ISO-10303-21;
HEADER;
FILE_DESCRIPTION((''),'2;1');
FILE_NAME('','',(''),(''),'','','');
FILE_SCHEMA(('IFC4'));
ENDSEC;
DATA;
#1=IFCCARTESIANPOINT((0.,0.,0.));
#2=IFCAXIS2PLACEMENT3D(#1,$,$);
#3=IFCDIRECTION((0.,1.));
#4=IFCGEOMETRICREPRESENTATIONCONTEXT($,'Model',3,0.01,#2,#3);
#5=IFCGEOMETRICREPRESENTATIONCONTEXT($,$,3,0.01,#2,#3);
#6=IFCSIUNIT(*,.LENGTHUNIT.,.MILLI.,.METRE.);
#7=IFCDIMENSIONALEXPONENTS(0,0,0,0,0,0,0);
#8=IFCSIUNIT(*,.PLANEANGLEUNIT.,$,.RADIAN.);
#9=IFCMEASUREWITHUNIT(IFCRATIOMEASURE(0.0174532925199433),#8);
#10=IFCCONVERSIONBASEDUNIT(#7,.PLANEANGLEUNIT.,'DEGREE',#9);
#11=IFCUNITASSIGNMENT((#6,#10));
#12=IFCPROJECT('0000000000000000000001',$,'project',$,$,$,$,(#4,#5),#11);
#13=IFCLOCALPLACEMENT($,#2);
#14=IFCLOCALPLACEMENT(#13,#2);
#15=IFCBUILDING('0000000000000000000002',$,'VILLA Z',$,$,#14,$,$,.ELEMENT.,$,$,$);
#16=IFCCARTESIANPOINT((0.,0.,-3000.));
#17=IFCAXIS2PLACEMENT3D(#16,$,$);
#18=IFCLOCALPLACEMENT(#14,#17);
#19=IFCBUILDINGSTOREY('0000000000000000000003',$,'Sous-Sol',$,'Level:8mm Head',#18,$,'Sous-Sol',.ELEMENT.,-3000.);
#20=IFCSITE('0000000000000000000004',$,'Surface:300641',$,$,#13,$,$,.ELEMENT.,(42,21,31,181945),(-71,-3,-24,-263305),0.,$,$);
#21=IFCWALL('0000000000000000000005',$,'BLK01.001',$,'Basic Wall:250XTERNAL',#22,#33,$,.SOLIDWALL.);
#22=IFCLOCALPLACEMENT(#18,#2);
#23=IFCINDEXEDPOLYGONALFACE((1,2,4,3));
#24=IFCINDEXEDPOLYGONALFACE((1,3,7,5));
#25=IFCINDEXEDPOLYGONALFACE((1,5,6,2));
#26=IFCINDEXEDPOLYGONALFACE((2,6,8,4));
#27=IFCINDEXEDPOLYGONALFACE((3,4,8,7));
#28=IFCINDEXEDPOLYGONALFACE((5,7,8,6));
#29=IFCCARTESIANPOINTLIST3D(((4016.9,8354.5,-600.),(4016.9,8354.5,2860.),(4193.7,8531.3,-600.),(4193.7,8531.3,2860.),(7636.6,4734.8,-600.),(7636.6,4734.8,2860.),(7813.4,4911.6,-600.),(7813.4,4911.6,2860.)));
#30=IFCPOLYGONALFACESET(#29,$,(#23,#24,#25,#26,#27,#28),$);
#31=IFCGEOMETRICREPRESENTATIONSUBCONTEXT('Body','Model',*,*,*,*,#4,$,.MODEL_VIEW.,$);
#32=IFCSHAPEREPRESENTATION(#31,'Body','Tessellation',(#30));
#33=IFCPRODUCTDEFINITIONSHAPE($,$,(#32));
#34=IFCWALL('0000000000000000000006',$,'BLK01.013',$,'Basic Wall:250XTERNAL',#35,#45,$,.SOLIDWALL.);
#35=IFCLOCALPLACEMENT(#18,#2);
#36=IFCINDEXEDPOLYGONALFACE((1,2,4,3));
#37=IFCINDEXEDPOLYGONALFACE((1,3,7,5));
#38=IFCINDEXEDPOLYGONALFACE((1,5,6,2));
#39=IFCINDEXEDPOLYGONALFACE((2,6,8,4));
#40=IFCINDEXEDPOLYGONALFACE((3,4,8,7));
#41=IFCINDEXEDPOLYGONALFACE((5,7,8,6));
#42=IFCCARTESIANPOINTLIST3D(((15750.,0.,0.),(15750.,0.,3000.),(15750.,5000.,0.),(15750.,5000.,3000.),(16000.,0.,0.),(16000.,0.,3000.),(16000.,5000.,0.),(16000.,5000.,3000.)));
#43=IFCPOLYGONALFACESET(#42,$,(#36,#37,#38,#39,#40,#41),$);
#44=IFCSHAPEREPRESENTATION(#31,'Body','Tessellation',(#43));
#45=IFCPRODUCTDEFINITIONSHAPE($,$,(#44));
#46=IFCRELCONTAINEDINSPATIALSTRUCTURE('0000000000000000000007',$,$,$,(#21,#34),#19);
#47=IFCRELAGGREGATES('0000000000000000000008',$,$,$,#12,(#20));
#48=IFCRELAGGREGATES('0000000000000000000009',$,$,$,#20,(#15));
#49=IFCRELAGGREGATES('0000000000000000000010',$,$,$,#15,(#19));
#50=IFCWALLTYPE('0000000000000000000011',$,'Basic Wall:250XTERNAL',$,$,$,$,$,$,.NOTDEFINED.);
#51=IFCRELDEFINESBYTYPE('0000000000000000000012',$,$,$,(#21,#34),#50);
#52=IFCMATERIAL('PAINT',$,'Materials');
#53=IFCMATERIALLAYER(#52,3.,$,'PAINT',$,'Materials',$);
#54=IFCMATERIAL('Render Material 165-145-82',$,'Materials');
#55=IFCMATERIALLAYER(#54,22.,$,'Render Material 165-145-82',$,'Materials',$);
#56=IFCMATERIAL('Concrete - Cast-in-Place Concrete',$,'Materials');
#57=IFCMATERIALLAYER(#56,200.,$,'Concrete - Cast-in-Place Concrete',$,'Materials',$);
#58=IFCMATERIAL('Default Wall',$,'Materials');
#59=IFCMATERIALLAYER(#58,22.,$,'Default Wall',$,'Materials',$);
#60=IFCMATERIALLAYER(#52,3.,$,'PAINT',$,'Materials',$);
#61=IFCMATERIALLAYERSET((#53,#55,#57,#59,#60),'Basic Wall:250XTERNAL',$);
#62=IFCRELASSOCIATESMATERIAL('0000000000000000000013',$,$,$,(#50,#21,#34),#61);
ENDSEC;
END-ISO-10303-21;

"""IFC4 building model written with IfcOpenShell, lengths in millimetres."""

from ifc_helpers import new_model, entity, si_unit, converted_unit, direction, frame, frame_2d, origin, place, context, subcontext, project, spatial, polyline, rectangle, extrude, clip, bounded_halfspace, material, layer, layer_set, layer_usage, type_object, element, save


model = new_model("IFC4")

# Units and contexts
model_context = context("Model", 3, precision=0.01, world=origin(), true_north=direction((0.0, 1.0)))
context_of_model = context(None, 3, precision=0.01, world=origin(), true_north=direction((0.0, 1.0)))
body_context = subcontext(model_context, "Body", "Model", "MODEL_VIEW")
ifc_project = project(units=[si_unit("LENGTHUNIT", "METRE", prefix="MILLI"), converted_unit("PLANEANGLEUNIT", "DEGREE", entity("IfcRatioMeasure", 0.0174532925199433), si_unit("PLANEANGLEUNIT", "RADIAN"), dimensions=[0, 0, 0, 0, 0, 0, 0])], contexts=[model_context, context_of_model])

# Site, building, storey
site_placement = place(None, origin())
site = spatial("IfcSite", under=ifc_project, at=site_placement, Name="Surface:300641", CompositionType="ELEMENT", RefLatitude=(42, 21, 31, 181945), RefLongitude=(-71, -3, -24, -263305), RefElevation=0.0)
building_placement = place(site_placement, origin())
building = spatial("IfcBuilding", under=site, at=building_placement, Name="VILLA Z", CompositionType="ELEMENT")
storey_placement = place(building_placement, frame((0.0, 0.0, -3000.0)))
storey = spatial("IfcBuildingStorey", under=building, at=storey_placement, Name="Sous-Sol", ObjectType="Level:8mm Head", LongName="Sous-Sol", CompositionType="ELEMENT", Elevation=-3000.0)

# Shared definitions
ifc_material_1 = material(Name="Concrete - Cast-in-Place Concrete", Category="Materials")

# Walls
ifc_material_2 = material(Name="PAINT", Category="Materials")
ifc_layer_1 = layer(ifc_material_2, 3.0, Name="PAINT", Category="Materials")
ifc_material_3 = material(Name="Render Material 165-145-82", Category="Materials")
ifc_layer_2 = layer(ifc_material_3, 22.0, Name="Render Material 165-145-82", Category="Materials")
ifc_layer_3 = layer(ifc_material_1, 200.0, Name="Concrete - Cast-in-Place Concrete", Category="Materials")
ifc_material_4 = material(Name="Default Wall", Category="Materials")
ifc_layer_4 = layer(ifc_material_4, 22.0, Name="Default Wall", Category="Materials")
ifc_layer_5 = layer(ifc_material_2, 3.0, Name="PAINT", Category="Materials")
ifc_layer_set = layer_set([ifc_layer_1, ifc_layer_2, ifc_layer_3, ifc_layer_4, ifc_layer_5], Name="Basic Wall:250XTERNAL")
wall_type = type_object("IfcWallType", Name="Basic Wall:250XTERNAL", PredefinedType="NOTDEFINED", material=ifc_layer_set)
ifc_layer_usage_1 = layer_usage(ifc_layer_set, "AXIS2", "NEGATIVE", 125.0)
wall_1_placement = place(storey_placement, frame((7725.0, 4823.2, -600.0), z_axis=(0.0, 0.0, 1.0), x_axis=(-0.707107, 0.707107, 0.0)))
element("IfcWall", 1, at=wall_1_placement, inside=storey, type_object=wall_type, material=ifc_layer_usage_1, Name="BLK01.001", ObjectType="Basic Wall:250XTERNAL", PredefinedType="SOLIDWALL", context=body_context, shape_type="Clipping", body=[
    clip(extrude(rectangle(XDim=5119.0, YDim=250.0, at=frame_2d((2559.5, 0.0), x_axis=(-1.0, 0.0))), origin(), (0.0, 0.0, 1.0), 3460.0), bounded_halfspace(frame((0.0, -125.0, 3460.0), z_axis=(0.0, 0.0, -1.0), x_axis=(-0.707107, -0.707107, 0.0)), True, frame((0.0, -125.0, 3460.0)), polyline([(0.0, 0.0), (4869.0, 0.0), (5119.0, 0.0), (5119.0, 250.0), (0.0, 250.0), (0.0, 0.0)]))),
])
ifc_layer_usage_2 = layer_usage(ifc_layer_set, "AXIS2", "NEGATIVE", 125.0)
wall_2_placement = place(storey_placement, frame((15875.0, 0.0, 0.0), z_axis=(0.0, 0.0, 1.0), x_axis=(0.0, 1.0, 0.0)))
element("IfcWall", 2, at=wall_2_placement, inside=storey, type_object=wall_type, material=ifc_layer_usage_2, Name="BLK01.013", ObjectType="Basic Wall:250XTERNAL", PredefinedType="SOLIDWALL", context=body_context, shape_type="SweptSolid", body=[
    extrude(rectangle(XDim=5000.0, YDim=250.0, at=frame_2d((2500.0, 0.0), x_axis=(-1.0, 0.0))), origin(), (0.0, 0.0, 1.0), 3000.0),
])

save(model, "model.ifc")
